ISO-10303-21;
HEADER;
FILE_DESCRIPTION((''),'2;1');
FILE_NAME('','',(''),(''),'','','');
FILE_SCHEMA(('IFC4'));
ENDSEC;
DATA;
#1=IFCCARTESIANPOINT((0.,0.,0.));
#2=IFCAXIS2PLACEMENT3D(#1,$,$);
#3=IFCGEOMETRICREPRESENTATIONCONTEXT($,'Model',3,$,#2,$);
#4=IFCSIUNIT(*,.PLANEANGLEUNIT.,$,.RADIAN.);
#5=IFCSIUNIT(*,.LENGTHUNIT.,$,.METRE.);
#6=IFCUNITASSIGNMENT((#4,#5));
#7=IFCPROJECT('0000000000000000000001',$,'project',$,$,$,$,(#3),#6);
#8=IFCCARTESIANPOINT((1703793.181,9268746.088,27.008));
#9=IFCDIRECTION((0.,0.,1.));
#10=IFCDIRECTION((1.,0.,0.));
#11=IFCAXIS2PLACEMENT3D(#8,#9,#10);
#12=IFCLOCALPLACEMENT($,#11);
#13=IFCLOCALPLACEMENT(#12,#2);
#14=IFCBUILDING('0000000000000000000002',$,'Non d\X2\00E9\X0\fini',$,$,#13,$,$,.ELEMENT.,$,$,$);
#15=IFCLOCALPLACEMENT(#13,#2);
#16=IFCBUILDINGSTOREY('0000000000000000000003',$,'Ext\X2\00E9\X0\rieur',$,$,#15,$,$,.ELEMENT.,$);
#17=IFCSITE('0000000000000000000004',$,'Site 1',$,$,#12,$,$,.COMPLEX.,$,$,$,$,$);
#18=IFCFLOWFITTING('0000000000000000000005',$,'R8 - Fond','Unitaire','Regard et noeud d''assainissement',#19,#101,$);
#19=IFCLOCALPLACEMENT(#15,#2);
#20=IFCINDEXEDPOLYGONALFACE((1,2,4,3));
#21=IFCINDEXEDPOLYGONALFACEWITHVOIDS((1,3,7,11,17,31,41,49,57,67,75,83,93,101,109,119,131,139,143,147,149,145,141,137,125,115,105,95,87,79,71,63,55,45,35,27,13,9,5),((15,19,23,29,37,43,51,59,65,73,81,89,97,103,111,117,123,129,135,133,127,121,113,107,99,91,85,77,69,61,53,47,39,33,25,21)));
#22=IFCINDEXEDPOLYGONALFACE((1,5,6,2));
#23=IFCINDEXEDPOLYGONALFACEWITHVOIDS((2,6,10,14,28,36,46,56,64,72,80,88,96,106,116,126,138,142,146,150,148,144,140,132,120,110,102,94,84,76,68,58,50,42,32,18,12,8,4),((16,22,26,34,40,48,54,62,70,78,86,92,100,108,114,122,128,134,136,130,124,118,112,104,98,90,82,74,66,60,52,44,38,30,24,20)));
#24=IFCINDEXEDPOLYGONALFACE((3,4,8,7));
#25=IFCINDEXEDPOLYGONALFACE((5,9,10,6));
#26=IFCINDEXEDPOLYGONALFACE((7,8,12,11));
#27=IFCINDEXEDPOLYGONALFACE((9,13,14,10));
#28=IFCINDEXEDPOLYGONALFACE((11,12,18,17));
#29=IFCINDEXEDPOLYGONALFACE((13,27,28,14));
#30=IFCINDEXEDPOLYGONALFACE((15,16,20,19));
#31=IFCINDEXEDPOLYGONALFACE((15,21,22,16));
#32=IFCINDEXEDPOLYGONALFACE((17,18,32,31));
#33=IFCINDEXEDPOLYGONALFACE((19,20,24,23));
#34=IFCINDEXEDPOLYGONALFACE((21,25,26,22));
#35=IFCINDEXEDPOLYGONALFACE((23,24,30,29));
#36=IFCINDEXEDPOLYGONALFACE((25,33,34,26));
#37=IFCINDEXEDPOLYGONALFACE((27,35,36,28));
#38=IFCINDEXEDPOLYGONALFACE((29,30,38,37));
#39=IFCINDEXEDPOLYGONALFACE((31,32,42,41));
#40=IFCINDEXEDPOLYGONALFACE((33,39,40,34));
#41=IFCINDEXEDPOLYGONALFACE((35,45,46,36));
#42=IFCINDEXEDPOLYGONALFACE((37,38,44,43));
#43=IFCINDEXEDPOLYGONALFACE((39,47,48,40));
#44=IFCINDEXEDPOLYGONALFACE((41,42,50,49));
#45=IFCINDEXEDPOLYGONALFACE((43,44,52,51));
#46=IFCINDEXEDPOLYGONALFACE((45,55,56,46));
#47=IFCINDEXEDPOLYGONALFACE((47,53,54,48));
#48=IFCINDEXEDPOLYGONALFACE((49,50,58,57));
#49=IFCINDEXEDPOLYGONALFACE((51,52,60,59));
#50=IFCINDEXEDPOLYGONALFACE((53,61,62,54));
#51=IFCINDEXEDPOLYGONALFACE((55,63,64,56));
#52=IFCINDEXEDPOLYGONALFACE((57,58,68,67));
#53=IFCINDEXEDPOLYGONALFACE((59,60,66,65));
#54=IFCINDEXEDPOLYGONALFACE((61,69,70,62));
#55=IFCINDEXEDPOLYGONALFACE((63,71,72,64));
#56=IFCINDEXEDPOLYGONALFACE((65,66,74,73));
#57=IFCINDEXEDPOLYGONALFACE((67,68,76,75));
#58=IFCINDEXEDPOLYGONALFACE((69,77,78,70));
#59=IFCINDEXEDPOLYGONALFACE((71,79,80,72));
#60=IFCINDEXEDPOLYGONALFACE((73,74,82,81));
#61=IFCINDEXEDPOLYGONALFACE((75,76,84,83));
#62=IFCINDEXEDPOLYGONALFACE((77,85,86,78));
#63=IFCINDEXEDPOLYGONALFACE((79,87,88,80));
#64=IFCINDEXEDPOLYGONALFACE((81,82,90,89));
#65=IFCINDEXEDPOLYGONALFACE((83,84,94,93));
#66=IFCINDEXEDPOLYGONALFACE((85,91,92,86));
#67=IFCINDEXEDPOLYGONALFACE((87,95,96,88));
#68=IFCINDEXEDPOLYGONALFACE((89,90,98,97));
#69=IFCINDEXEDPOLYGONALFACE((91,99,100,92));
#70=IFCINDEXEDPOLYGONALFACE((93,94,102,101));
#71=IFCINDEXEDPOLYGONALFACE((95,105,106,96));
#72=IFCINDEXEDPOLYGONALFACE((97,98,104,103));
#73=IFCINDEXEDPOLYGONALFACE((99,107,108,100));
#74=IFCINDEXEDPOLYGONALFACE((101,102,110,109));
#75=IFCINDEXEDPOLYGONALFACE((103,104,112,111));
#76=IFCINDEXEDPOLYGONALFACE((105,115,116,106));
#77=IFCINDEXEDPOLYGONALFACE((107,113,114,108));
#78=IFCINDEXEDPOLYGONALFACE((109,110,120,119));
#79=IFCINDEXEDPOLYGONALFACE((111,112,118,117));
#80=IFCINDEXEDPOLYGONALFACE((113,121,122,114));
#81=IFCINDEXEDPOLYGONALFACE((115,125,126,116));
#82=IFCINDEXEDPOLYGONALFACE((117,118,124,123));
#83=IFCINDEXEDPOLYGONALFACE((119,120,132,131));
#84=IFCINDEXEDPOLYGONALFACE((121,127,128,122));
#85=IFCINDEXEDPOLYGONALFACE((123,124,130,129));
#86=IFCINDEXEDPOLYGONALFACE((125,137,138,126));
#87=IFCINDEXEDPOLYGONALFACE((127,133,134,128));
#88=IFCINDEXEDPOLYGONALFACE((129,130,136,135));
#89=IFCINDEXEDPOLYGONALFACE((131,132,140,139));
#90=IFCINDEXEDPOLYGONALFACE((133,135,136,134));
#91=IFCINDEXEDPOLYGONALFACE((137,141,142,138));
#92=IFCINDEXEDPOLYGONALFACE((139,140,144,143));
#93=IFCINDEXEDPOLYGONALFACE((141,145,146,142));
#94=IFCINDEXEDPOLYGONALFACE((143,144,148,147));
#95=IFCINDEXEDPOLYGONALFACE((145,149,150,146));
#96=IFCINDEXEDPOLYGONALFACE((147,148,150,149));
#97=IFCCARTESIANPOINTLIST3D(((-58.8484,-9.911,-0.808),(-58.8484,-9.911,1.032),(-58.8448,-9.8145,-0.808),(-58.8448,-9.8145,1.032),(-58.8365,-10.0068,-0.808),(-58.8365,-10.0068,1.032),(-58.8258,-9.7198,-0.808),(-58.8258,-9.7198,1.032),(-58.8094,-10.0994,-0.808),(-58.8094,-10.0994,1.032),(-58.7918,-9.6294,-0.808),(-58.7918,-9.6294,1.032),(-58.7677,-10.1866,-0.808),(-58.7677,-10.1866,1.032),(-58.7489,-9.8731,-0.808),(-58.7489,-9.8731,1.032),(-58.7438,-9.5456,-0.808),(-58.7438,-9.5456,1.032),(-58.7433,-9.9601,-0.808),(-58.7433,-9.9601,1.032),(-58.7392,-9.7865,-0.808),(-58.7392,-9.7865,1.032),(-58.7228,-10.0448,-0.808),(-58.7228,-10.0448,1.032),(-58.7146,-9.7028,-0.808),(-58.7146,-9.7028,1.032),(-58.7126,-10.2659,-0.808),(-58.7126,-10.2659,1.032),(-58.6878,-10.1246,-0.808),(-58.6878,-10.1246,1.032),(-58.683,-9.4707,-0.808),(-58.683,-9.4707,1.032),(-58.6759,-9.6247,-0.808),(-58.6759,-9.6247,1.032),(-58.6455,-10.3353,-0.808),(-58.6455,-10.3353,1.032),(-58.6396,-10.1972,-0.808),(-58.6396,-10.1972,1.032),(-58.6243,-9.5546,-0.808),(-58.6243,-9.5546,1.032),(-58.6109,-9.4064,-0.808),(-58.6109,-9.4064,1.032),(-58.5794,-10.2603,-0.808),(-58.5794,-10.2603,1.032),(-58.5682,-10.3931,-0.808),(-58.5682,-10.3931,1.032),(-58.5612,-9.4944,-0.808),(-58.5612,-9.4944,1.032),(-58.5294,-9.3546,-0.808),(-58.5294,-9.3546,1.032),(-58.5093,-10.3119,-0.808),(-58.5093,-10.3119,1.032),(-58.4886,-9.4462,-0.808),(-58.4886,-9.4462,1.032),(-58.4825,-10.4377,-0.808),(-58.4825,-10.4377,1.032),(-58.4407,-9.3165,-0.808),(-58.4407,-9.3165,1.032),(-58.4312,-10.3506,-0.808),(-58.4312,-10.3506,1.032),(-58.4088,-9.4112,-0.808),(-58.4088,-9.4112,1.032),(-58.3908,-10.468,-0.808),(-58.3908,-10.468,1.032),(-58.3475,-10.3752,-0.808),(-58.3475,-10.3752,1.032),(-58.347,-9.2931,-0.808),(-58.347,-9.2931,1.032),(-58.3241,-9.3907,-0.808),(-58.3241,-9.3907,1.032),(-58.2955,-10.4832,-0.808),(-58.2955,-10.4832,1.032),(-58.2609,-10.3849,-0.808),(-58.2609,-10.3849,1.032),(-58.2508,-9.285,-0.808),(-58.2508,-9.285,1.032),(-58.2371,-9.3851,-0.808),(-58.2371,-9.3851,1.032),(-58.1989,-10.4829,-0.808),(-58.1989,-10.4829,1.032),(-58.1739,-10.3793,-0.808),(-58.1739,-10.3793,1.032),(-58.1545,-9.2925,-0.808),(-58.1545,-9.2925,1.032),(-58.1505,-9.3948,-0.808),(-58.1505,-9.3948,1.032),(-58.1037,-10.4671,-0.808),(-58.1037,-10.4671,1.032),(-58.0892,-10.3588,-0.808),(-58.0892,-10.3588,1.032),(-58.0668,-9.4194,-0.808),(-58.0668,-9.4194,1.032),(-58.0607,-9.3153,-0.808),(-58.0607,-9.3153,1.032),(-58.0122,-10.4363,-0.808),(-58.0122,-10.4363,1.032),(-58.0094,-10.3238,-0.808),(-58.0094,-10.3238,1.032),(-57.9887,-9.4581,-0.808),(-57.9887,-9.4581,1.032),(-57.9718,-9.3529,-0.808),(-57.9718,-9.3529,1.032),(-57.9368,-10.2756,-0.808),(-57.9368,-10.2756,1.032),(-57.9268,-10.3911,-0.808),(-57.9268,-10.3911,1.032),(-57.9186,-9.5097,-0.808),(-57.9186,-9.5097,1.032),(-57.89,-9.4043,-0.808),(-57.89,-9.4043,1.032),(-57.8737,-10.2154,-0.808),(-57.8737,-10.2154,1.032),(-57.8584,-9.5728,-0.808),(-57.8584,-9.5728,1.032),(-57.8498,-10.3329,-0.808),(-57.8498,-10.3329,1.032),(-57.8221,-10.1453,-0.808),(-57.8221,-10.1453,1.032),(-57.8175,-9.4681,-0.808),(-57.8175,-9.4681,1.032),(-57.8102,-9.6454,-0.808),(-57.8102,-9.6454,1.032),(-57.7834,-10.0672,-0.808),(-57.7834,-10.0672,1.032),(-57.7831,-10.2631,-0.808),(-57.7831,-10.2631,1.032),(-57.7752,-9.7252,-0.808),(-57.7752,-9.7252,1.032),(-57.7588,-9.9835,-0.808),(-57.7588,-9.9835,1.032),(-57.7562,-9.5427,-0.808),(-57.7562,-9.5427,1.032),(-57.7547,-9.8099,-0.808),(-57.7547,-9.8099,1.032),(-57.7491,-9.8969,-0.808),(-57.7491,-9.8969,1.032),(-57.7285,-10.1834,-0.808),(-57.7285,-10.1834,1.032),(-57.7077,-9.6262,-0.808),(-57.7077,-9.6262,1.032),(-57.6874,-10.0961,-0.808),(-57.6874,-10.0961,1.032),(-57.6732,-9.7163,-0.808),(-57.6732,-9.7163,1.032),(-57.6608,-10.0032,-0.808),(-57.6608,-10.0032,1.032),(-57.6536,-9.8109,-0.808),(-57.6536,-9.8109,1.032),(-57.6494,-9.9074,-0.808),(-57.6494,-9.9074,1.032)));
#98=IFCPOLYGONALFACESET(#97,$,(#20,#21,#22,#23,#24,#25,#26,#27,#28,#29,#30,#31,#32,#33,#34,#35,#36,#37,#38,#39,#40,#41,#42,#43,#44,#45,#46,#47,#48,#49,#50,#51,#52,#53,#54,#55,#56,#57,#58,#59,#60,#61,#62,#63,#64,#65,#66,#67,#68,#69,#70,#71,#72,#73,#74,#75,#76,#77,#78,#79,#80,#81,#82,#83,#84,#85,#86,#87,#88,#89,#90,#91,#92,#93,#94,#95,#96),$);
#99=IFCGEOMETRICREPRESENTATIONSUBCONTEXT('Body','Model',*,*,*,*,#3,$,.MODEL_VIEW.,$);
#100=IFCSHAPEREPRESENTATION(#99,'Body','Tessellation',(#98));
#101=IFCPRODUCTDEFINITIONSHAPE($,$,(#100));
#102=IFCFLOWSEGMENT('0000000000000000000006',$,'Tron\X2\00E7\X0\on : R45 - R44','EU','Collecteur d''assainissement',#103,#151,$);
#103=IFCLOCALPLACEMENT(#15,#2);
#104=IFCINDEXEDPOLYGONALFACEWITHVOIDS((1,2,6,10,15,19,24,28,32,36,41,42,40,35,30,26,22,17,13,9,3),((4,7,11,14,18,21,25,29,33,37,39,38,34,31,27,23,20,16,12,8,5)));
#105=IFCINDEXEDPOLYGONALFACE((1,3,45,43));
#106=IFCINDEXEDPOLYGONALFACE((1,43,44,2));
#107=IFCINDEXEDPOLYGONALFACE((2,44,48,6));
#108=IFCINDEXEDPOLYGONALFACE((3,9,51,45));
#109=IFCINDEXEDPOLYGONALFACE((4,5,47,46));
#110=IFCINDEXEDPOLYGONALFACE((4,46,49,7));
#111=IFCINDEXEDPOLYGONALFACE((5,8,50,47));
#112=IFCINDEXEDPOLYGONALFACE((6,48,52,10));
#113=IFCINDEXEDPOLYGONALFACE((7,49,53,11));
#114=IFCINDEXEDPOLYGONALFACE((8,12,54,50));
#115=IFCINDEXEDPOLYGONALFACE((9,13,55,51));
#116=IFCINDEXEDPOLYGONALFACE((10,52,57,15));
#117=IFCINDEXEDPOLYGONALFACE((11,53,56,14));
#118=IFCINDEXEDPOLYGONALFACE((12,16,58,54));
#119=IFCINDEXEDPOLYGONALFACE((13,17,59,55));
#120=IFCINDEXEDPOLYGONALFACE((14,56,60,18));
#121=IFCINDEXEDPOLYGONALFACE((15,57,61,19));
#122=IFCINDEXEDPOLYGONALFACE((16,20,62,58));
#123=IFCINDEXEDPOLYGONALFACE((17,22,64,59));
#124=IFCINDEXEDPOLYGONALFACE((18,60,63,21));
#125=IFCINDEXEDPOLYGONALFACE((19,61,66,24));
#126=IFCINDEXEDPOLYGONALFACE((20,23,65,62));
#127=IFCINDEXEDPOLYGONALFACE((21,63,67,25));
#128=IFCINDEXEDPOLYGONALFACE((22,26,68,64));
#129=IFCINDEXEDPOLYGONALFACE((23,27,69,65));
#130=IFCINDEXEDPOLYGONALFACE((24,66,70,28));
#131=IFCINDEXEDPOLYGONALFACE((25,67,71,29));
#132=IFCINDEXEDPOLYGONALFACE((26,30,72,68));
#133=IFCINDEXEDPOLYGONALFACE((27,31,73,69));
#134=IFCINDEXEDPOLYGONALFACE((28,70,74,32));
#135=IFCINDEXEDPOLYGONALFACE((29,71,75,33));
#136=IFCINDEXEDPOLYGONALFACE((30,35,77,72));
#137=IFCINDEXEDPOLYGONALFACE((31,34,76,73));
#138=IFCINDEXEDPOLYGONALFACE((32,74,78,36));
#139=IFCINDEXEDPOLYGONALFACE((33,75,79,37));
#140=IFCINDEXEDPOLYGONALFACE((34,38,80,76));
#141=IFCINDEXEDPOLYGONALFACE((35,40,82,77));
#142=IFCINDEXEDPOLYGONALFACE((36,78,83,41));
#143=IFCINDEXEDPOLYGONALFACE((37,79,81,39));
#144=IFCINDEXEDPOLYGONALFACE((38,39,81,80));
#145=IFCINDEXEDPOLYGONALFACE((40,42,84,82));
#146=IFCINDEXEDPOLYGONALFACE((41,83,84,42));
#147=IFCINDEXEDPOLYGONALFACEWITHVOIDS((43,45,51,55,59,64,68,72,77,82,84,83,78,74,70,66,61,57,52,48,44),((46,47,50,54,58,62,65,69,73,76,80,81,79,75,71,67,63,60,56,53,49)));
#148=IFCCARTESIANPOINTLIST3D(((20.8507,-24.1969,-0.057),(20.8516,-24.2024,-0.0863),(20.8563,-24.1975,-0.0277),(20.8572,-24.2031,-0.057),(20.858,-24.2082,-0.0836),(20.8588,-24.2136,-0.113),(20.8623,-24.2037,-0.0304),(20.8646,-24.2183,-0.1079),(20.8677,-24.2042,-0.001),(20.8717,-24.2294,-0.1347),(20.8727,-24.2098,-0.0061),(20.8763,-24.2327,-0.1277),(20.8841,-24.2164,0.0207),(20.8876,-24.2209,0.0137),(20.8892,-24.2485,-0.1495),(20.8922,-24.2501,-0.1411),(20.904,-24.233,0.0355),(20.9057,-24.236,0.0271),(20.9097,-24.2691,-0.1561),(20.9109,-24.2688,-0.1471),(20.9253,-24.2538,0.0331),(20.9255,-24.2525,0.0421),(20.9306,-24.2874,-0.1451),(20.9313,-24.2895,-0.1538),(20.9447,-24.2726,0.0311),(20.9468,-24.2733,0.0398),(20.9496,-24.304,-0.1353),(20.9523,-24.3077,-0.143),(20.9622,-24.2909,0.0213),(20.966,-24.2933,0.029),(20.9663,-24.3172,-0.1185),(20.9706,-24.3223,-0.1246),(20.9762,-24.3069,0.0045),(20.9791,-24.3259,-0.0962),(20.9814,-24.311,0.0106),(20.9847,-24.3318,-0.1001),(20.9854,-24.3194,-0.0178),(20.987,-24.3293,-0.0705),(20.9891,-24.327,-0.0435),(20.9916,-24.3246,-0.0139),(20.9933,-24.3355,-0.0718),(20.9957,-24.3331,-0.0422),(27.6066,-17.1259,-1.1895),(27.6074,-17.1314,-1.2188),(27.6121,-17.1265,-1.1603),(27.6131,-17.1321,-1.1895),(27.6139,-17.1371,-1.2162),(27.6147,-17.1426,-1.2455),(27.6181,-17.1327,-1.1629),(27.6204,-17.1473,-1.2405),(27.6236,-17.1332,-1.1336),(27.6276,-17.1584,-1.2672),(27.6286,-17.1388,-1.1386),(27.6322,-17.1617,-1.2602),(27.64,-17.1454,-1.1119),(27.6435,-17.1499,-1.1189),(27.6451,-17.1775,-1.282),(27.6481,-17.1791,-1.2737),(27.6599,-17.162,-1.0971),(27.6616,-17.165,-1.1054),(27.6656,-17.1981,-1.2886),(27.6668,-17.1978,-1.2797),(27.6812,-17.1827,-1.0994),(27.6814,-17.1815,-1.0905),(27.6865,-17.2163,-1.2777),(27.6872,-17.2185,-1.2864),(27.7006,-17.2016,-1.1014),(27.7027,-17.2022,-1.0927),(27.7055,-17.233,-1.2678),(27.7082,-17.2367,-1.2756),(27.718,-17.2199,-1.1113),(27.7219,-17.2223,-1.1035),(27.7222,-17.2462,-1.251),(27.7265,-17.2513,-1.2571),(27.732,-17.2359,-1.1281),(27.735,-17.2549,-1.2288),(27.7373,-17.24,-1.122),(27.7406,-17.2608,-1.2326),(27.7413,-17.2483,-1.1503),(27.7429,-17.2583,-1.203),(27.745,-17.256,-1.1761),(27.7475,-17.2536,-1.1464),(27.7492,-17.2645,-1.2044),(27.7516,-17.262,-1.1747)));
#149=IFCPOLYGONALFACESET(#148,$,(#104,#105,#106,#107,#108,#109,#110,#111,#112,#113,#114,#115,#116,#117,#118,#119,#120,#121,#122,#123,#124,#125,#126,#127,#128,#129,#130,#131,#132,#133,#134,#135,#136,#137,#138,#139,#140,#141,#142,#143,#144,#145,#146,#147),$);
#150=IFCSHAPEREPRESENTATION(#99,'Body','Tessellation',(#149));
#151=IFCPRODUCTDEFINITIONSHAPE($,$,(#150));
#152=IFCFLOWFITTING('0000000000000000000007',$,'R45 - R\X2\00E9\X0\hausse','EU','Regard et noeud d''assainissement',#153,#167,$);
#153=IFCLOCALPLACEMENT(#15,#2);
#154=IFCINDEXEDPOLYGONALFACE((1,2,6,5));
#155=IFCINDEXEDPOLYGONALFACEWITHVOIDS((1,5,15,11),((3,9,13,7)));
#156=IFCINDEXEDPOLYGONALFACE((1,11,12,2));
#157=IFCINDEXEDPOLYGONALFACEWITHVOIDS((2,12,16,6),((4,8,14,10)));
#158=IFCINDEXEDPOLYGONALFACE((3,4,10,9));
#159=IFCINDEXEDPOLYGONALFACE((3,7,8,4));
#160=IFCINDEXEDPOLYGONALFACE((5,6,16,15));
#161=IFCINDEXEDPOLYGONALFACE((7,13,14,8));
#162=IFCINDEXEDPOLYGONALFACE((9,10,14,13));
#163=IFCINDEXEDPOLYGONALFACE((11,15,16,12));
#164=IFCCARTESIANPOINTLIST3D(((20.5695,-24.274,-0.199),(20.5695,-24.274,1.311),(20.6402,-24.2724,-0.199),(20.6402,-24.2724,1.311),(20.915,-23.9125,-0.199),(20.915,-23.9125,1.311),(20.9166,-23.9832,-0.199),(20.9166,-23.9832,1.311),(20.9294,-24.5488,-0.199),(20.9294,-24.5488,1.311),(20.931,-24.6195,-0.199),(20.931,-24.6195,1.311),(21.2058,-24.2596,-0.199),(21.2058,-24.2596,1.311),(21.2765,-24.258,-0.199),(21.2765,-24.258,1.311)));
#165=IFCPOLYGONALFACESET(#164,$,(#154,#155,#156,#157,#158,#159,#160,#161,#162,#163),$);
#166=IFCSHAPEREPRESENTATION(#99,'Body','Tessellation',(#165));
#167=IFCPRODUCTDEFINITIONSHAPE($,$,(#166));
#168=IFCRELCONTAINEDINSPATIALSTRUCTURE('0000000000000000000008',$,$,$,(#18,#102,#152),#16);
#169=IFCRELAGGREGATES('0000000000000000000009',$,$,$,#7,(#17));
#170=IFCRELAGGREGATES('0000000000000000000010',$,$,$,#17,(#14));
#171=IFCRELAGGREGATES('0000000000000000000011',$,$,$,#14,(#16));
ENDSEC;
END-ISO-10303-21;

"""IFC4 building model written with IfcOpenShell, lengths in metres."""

from ifc_helpers import new_model, si_unit, frame, origin, origin_2d, place, context, subcontext, project, spatial, hollow_rectangle, hollow_circle, extrude, element, save


model = new_model("IFC4")

# Units and contexts
model_context = context("Model", 3, world=origin())
body_context = subcontext(model_context, "Body", "Model", "MODEL_VIEW")
ifc_project = project(units=[si_unit("PLANEANGLEUNIT", "RADIAN"), si_unit("LENGTHUNIT", "METRE")], contexts=[model_context])

# Site, building, storey
site_placement = place(None, frame((1703793.181, 9268746.088, 27.008), z_axis=(0.0, 0.0, 1.0), x_axis=(1.0, 0.0, 0.0)))
site = spatial("IfcSite", under=ifc_project, at=site_placement, Name="Site 1", CompositionType="COMPLEX")
building_placement = place(site_placement, origin())
building = spatial("IfcBuilding", under=site, at=building_placement, Name="Non défini", CompositionType="ELEMENT")
storey_placement = place(building_placement, origin())
storey = spatial("IfcBuildingStorey", under=building, at=storey_placement, Name="Extérieur", CompositionType="ELEMENT")

# Flow fitting
flow_fitting_1_placement = place(storey_placement, origin())
element("IfcFlowFitting", 1, at=flow_fitting_1_placement, inside=storey, Name="R8 - Fond", Description="Unitaire", ObjectType="Regard et noeud d'assainissement", context=body_context, shape_type="SweptSolid", body=[
    extrude(hollow_circle(Radius=0.6, WallThickness=0.1, at=origin_2d()), frame((-58.249, -9.885, -0.808), z_axis=(0.0, 0.0, 1.0), x_axis=(0.98, -0.197, 0.0)), (0.0, 0.0, 1.0), 1.84),
])

# Flow segment
flow_segment_1_placement = place(storey_placement, origin())
element("IfcFlowSegment", 2, at=flow_segment_1_placement, inside=storey, Name="Tronçon : R45 - R44", Description="EU", ObjectType="Collecteur d'assainissement", context=body_context, shape_type="SweptSolid", body=[
    extrude(hollow_circle(Radius=0.1, WallThickness=0.009, at=origin_2d()), frame((20.923, -24.266, -0.057), z_axis=(0.686, 0.718, -0.115), x_axis=(-0.723, 0.691, 0.0)), (0.0, 0.0, 1.0), 9.845),
])

# Flow fitting
for number, where, name in (
    (3, (0.0, 0.0, 0.0), "R45 - Réhausse"),
):
    element("IfcFlowFitting", number, at=place(storey_placement, frame(where)), inside=storey, Name=name, Description="EU", ObjectType="Regard et noeud d'assainissement", context=body_context, shape_type="SweptSolid", body=[
        extrude(hollow_rectangle(XDim=0.5, YDim=0.5, WallThickness=0.05, at=origin_2d()), frame((20.923, -24.266, -0.199), z_axis=(0.0, 0.0, 1.0), x_axis=(0.691, 0.723, 0.0)), (0.0, 0.0, 1.0), 1.51),
    ])

save(model, "model.ifc")
